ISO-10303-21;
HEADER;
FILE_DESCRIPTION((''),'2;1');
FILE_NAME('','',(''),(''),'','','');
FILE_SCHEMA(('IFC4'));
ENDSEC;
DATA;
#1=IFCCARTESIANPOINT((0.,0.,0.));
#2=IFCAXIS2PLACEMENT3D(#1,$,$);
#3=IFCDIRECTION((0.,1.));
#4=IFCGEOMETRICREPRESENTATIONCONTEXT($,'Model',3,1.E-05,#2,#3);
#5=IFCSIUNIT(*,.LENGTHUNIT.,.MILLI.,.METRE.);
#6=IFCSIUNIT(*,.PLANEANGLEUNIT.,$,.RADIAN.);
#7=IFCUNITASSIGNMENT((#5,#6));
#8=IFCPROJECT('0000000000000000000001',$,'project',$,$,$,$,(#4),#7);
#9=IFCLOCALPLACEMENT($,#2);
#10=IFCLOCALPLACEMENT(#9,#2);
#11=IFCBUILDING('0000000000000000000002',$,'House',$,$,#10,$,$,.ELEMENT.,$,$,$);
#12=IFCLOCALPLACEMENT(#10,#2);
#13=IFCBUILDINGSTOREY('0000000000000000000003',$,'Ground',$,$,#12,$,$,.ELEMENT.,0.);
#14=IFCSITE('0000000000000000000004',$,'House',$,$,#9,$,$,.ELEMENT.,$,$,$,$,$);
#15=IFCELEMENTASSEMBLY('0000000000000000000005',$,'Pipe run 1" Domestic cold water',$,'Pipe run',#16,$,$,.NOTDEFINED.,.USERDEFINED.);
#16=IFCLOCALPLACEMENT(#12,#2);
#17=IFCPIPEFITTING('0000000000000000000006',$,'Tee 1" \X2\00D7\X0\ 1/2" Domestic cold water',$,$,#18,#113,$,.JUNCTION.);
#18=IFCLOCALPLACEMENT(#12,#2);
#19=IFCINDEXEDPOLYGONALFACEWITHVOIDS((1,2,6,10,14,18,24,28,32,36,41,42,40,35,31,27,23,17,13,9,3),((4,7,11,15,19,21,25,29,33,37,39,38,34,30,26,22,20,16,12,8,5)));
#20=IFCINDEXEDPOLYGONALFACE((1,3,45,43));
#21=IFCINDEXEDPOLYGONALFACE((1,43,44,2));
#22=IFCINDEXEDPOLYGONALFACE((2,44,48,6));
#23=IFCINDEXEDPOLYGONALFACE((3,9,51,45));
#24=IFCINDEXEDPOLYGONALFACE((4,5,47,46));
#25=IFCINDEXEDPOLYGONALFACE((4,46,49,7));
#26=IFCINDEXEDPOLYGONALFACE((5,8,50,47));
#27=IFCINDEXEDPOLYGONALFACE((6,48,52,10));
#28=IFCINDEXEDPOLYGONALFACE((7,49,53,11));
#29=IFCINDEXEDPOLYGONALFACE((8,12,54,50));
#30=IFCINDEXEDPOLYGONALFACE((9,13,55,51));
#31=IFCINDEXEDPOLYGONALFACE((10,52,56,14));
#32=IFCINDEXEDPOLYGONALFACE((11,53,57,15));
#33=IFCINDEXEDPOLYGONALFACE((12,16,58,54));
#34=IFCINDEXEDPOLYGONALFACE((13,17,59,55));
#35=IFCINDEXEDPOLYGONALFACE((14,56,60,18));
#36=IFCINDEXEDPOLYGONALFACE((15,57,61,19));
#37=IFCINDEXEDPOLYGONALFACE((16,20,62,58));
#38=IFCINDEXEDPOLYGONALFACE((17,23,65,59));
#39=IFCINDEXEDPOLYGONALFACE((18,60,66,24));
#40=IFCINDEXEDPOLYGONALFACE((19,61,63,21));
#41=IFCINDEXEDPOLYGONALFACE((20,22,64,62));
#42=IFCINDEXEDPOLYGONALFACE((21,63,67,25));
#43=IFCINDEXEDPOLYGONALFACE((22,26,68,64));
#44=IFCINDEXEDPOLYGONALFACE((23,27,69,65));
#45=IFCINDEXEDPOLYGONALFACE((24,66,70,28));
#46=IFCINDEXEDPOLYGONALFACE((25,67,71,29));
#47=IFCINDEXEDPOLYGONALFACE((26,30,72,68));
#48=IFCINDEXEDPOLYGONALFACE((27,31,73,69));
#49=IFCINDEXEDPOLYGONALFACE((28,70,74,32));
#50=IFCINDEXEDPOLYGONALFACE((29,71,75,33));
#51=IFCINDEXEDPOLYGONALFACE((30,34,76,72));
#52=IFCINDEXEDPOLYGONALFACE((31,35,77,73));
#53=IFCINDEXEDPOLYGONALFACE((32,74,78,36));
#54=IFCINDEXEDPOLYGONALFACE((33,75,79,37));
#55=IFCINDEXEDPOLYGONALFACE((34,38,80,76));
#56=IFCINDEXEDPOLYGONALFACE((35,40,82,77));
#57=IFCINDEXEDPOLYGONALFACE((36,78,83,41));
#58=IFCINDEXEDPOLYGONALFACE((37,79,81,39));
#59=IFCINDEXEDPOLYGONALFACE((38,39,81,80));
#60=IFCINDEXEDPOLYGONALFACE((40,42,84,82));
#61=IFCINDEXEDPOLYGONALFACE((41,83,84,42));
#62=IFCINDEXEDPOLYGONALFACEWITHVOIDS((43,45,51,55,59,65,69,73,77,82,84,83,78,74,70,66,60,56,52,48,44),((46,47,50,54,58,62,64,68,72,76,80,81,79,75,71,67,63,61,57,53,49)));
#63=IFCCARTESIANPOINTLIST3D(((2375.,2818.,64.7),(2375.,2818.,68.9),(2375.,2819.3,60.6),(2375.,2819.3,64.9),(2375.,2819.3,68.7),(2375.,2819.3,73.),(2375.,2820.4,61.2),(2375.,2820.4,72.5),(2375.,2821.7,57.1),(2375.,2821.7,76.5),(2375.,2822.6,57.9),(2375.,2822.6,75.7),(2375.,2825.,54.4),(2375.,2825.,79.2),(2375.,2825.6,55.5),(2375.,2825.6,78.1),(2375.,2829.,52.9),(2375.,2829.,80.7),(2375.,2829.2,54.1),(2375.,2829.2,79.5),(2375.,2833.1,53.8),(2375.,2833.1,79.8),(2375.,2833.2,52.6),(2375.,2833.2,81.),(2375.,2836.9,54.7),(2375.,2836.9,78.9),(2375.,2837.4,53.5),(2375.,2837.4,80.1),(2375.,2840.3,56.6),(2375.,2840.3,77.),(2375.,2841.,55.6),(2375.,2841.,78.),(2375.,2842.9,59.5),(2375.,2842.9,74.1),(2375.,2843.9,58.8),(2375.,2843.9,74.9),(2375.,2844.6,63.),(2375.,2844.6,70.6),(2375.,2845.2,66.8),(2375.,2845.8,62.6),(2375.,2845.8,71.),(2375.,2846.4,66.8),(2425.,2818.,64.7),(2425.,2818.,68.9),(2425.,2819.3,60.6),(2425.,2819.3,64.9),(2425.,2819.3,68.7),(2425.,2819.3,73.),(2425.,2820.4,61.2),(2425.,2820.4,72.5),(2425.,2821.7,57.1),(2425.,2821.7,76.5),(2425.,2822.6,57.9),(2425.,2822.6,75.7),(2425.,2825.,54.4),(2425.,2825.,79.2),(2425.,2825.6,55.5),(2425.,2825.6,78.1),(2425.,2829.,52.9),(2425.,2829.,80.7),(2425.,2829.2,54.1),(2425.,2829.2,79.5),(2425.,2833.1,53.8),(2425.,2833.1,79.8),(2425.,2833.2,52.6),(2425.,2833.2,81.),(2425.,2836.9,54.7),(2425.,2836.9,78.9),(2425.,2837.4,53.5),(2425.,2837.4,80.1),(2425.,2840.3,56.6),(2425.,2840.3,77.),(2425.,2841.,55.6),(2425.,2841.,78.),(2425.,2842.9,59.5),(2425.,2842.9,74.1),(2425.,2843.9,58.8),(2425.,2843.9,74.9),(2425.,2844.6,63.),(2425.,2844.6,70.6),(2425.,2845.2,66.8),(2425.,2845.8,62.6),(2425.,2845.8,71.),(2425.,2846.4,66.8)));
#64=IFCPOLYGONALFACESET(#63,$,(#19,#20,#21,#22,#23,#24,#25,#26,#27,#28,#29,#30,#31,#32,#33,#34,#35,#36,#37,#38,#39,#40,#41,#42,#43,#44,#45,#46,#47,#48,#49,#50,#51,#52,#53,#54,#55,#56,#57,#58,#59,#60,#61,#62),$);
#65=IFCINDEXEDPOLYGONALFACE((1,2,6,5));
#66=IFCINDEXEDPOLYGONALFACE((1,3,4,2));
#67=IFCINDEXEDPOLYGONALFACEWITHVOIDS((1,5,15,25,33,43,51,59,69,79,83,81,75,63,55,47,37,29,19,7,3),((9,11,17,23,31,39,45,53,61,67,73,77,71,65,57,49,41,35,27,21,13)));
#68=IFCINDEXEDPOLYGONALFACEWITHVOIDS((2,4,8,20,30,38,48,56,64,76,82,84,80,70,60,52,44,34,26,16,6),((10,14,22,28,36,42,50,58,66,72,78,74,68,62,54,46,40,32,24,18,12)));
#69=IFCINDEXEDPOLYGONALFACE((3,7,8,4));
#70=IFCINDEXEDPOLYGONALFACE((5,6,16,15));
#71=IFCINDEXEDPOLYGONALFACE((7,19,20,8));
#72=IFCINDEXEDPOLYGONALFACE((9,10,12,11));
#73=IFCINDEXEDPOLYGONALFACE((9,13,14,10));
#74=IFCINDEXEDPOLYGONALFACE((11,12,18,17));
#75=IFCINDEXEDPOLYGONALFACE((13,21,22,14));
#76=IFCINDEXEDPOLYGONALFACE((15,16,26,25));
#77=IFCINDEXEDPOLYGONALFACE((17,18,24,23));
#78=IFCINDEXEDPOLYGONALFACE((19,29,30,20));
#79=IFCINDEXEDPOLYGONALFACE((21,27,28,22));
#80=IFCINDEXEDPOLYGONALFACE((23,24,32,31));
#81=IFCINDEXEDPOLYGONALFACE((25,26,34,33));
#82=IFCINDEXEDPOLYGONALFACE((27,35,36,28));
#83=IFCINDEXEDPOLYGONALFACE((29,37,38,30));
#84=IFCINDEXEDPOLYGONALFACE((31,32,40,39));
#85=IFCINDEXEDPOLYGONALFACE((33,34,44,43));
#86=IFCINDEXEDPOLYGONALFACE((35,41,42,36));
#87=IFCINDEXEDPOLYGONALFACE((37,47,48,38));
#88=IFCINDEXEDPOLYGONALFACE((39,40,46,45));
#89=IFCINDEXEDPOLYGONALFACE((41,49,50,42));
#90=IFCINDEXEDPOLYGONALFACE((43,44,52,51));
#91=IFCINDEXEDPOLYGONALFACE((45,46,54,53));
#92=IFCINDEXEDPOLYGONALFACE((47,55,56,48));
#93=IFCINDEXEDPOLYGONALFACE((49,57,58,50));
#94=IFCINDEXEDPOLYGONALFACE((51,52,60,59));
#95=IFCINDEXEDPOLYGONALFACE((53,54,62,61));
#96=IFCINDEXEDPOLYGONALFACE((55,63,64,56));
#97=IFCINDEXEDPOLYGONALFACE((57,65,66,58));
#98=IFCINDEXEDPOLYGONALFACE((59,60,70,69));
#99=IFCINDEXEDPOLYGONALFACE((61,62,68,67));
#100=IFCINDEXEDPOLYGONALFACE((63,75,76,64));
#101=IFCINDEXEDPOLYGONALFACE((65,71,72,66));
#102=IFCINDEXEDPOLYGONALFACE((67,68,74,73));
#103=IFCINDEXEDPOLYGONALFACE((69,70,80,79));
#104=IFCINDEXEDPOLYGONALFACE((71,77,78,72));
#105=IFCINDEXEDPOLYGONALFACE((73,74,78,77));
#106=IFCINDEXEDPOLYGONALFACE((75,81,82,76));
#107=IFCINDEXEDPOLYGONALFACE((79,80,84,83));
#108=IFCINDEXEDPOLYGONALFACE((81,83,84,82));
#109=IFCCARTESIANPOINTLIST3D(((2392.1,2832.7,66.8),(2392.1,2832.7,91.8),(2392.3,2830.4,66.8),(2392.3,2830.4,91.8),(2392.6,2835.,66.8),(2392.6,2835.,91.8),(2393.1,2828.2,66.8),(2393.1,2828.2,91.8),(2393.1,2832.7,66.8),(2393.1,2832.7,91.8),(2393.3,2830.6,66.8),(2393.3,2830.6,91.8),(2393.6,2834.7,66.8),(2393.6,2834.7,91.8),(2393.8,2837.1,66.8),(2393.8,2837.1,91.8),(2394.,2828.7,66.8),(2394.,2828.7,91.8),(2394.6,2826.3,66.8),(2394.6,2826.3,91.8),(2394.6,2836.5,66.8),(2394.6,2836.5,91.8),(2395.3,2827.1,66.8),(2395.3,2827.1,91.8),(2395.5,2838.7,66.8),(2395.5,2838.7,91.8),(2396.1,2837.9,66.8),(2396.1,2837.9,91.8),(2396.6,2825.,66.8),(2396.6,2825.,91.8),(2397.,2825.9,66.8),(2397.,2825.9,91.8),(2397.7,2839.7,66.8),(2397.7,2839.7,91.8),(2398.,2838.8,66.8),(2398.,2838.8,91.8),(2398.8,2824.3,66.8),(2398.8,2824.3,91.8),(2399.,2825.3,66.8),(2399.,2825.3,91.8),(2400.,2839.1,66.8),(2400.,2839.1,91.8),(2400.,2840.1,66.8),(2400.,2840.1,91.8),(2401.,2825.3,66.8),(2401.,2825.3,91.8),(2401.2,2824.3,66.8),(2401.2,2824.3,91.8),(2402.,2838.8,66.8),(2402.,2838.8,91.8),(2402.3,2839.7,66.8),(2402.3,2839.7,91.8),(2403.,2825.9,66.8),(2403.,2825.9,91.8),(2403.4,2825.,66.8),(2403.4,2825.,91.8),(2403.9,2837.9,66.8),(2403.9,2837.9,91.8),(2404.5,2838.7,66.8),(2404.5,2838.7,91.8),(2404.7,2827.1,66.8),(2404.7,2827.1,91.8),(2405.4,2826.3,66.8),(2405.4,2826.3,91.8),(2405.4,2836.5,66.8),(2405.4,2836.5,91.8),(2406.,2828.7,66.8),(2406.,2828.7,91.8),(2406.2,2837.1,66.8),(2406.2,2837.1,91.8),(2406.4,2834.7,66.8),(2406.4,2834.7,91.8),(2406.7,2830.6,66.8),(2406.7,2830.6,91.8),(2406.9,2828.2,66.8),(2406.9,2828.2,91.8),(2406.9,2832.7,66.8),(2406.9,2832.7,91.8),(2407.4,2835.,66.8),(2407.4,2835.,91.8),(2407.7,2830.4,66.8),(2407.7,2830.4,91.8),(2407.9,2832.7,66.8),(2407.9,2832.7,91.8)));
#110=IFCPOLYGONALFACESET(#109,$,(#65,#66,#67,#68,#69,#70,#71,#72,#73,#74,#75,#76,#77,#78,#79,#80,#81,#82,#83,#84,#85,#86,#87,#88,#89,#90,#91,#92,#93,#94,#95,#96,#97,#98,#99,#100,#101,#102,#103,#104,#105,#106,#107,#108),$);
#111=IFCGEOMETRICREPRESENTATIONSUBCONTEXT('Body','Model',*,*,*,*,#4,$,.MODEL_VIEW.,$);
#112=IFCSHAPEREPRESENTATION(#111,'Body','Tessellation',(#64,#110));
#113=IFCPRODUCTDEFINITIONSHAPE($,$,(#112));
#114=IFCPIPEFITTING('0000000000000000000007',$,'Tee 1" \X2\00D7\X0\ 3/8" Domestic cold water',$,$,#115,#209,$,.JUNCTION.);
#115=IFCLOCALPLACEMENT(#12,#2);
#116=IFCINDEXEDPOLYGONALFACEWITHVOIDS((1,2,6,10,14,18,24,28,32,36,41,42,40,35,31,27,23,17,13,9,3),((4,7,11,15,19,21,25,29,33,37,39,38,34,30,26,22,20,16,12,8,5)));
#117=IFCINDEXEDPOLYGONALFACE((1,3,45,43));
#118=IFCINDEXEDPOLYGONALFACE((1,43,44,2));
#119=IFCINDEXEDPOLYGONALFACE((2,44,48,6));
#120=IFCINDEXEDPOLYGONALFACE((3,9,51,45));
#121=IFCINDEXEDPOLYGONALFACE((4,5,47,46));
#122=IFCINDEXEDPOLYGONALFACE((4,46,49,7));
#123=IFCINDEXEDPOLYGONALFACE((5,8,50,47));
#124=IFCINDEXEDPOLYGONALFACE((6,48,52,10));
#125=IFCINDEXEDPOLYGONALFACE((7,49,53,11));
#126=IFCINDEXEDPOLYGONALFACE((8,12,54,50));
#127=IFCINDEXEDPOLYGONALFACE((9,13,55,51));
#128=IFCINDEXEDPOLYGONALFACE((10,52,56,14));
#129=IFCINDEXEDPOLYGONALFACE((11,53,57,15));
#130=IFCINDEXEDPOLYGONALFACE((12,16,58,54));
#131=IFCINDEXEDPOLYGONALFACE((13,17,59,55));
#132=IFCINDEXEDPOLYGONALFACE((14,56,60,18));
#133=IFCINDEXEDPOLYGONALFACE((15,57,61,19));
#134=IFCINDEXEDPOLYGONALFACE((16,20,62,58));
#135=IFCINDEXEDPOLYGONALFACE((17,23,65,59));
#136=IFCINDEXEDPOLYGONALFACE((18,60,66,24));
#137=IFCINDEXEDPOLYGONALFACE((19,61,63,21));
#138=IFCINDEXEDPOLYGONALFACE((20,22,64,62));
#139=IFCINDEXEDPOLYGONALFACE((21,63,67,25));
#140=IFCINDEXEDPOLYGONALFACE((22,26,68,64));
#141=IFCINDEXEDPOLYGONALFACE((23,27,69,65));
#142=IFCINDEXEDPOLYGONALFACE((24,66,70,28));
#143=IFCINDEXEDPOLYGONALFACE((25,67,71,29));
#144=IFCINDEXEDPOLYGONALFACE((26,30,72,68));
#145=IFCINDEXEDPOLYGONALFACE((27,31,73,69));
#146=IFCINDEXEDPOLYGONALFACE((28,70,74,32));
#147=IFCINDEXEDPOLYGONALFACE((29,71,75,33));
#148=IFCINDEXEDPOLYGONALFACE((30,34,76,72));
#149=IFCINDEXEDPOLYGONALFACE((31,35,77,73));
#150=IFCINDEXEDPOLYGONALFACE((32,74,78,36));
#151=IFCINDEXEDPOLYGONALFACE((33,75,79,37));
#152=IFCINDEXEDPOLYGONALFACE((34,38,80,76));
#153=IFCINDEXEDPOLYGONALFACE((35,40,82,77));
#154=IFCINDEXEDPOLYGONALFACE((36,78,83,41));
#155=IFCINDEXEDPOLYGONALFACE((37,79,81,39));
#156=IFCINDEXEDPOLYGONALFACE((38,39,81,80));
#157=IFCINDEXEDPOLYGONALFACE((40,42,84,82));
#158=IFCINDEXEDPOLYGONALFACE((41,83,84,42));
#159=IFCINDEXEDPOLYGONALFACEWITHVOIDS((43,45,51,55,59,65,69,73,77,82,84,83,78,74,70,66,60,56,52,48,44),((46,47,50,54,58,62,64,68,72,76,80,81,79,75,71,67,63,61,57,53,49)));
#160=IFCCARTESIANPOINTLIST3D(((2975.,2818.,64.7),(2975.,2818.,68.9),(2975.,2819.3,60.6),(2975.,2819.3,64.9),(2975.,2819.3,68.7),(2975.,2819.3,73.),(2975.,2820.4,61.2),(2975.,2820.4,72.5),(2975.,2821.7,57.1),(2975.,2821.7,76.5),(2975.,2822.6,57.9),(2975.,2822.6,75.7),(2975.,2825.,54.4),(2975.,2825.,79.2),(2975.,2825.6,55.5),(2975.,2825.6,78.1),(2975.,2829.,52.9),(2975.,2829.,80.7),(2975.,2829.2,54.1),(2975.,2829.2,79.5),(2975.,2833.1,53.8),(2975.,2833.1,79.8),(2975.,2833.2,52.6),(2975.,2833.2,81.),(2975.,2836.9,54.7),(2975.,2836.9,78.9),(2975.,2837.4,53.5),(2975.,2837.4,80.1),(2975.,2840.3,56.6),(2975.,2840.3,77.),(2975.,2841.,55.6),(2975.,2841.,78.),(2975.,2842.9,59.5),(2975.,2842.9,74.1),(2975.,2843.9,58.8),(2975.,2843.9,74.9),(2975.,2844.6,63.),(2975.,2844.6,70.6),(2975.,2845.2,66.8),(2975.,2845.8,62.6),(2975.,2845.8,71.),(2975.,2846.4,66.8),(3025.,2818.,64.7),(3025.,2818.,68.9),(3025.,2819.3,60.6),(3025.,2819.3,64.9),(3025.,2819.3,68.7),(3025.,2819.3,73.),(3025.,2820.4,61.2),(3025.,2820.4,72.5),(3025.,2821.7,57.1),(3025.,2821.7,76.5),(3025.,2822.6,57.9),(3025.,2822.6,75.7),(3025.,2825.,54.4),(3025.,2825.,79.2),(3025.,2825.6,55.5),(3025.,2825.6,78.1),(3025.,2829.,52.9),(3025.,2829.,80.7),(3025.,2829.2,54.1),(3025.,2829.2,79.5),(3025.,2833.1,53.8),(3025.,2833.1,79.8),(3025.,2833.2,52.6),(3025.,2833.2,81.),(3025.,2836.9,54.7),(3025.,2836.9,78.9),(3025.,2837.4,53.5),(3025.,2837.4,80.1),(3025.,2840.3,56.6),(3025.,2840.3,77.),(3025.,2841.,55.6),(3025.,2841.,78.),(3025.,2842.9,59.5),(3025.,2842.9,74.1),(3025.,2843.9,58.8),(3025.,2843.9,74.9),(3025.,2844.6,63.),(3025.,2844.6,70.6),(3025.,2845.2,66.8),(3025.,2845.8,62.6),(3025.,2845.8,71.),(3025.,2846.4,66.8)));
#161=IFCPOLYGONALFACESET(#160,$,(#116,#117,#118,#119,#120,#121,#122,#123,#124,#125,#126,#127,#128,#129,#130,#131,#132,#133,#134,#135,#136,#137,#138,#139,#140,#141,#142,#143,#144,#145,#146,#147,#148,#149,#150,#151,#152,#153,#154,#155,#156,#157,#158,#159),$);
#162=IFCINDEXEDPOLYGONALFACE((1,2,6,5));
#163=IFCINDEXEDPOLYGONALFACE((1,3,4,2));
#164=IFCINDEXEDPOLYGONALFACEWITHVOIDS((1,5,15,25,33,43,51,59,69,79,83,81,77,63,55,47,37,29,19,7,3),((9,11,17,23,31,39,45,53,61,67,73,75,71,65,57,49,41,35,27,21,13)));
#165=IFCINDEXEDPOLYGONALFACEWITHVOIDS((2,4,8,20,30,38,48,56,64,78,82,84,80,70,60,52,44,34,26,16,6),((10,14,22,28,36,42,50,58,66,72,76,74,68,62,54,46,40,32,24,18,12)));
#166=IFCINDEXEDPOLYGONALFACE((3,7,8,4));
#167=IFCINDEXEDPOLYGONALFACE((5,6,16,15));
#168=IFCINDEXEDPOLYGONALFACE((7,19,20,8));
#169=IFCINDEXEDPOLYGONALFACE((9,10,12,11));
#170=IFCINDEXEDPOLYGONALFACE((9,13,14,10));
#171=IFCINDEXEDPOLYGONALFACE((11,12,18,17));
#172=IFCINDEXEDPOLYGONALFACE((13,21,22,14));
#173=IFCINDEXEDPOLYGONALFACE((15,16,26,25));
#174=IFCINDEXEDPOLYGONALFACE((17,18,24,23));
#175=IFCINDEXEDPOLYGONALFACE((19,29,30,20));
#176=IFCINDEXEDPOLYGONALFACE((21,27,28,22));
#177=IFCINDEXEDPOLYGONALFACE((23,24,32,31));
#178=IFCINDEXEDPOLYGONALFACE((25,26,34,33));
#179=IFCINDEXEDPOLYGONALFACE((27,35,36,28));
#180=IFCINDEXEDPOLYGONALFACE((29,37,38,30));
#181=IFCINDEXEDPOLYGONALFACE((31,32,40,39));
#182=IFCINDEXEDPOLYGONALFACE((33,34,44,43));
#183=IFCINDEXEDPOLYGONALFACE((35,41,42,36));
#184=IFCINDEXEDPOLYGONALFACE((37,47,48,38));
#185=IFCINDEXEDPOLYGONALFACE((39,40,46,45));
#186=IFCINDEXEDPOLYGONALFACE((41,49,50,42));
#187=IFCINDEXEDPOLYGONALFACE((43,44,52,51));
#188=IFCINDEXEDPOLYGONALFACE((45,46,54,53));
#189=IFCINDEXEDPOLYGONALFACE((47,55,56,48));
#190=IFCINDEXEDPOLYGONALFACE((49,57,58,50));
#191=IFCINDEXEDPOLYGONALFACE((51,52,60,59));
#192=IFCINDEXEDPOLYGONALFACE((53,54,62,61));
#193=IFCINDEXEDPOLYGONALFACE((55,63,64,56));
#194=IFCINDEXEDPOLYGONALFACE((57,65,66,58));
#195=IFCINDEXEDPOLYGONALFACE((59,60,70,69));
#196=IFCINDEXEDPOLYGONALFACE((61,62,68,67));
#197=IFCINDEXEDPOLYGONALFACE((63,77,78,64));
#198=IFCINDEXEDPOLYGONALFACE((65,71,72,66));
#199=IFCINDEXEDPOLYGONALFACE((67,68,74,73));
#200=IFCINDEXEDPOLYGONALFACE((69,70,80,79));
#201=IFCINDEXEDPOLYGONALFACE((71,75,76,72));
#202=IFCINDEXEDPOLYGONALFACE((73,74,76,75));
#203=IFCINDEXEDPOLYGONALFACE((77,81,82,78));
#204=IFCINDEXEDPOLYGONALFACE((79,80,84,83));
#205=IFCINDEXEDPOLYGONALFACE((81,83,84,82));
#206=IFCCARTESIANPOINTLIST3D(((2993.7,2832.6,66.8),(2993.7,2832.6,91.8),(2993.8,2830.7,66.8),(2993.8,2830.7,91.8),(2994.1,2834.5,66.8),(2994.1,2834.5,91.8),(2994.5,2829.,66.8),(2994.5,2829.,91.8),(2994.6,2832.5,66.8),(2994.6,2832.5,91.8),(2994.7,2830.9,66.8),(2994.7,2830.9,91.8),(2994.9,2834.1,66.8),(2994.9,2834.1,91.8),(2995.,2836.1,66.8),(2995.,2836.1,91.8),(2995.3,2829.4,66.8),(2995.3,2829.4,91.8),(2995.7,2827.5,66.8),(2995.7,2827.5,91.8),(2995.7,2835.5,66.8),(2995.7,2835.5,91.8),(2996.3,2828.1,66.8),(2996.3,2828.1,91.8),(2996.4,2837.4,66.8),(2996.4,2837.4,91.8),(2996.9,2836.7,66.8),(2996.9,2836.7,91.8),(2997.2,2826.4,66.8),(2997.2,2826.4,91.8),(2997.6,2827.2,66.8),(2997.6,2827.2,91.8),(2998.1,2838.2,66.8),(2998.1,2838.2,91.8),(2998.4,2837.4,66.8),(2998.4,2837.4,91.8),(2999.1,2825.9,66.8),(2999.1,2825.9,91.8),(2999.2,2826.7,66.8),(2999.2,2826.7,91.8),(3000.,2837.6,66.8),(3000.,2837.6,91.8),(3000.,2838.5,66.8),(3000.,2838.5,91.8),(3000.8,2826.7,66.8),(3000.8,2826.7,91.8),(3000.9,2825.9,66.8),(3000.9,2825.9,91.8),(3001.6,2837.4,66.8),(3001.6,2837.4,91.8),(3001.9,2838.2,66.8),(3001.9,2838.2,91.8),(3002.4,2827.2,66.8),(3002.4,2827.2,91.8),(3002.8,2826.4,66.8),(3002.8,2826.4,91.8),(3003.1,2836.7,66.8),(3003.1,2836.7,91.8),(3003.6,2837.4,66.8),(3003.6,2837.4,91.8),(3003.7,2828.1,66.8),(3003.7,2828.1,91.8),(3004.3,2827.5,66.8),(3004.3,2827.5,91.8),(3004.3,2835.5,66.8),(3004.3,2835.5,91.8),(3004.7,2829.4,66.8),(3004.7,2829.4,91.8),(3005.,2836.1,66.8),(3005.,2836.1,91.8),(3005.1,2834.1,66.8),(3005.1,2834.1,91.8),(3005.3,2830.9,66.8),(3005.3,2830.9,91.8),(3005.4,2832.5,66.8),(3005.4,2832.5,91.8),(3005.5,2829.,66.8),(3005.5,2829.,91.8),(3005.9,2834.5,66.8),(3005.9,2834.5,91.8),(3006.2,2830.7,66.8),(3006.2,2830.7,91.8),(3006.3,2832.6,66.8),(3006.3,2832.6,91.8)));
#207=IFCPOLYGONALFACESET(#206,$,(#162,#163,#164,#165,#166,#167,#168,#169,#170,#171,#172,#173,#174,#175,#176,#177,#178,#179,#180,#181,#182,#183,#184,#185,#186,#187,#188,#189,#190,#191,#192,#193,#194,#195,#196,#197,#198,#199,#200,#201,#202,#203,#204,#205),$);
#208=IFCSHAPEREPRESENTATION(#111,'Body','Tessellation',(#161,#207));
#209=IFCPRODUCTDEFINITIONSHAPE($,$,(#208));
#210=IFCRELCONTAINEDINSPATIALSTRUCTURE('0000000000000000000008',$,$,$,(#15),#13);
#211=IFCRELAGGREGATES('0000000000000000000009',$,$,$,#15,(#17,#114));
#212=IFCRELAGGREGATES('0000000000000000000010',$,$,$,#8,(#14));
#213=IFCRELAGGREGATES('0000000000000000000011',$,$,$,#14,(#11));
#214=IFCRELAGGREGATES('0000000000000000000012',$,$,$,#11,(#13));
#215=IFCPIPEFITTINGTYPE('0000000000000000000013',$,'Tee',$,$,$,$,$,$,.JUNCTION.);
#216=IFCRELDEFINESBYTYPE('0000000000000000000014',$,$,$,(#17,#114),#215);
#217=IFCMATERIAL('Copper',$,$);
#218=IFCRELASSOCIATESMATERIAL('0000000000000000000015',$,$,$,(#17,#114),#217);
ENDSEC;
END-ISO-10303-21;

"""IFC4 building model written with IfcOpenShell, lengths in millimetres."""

from ifc_helpers import new_model, si_unit, direction, frame, origin, origin_with_axes, origin_2d, place, context, subcontext, project, spatial, hollow_circle, extrude, material, type_object, element, aggregate, save


model = new_model("IFC4")

# Units and contexts
model_context = context("Model", 3, precision=1e-05, world=origin(), true_north=direction((0.0, 1.0)))
body_context = subcontext(model_context, "Body", "Model", "MODEL_VIEW")
ifc_project = project(units=[si_unit("LENGTHUNIT", "METRE", prefix="MILLI"), si_unit("PLANEANGLEUNIT", "RADIAN")], contexts=[model_context])

# Site, building, storey
site_placement = place(None, origin())
site = spatial("IfcSite", under=ifc_project, at=site_placement, Name="House", CompositionType="ELEMENT")
building_placement = place(site_placement, origin())
building = spatial("IfcBuilding", under=site, at=building_placement, Name="House", CompositionType="ELEMENT")
storey_placement = place(building_placement, origin())
storey = spatial("IfcBuildingStorey", under=building, at=storey_placement, Name="Ground", CompositionType="ELEMENT", Elevation=0.0)

# Shared definitions
ifc_material = material(Name="Copper")

# Element assembly
assembly_1_placement = place(storey_placement, origin_with_axes())
assembly_1 = element("IfcElementAssembly", 1, at=assembly_1_placement, inside=storey, Name="Pipe run 1\" Domestic cold water", ObjectType="Pipe run", AssemblyPlace="NOTDEFINED", PredefinedType="USERDEFINED")

# Pipe fittings
pipe_fitting_type_1 = type_object("IfcPipeFittingType", Name="Tee", PredefinedType="JUNCTION")
pipe_fitting_1_placement = place(storey_placement, origin_with_axes())
pipe_fitting_1 = element("IfcPipeFitting", 2, at=pipe_fitting_1_placement, type_object=pipe_fitting_type_1, material=ifc_material, Name="Tee 1\" × 1/2\" Domestic cold water", PredefinedType="JUNCTION", context=body_context, shape_type="SweptSolid", body=[
    extrude(hollow_circle(Radius=14.3, WallThickness=1.3, at=origin_2d()), frame((2375.0, 2832.1, 66.8), z_axis=(1.0, 0.0, 0.0), x_axis=(0.0, 1.0, 0.0)), (0.0, 0.0, 1.0), 50.0),
    extrude(hollow_circle(Radius=7.9, WallThickness=1.0, at=origin_2d()), frame((2400.0, 2832.1, 66.8), z_axis=(0.0, 0.0, 1.0), x_axis=(0.0, 1.0, 0.0)), (0.0, 0.0, 1.0), 25.0),
])
pipe_fitting_2_placement = place(storey_placement, origin_with_axes())
pipe_fitting_2 = element("IfcPipeFitting", 3, at=pipe_fitting_2_placement, type_object=pipe_fitting_type_1, material=ifc_material, Name="Tee 1\" × 3/8\" Domestic cold water", PredefinedType="JUNCTION", context=body_context, shape_type="SweptSolid", body=[
    extrude(hollow_circle(Radius=14.3, WallThickness=1.3, at=origin_2d()), frame((2975.0, 2832.1, 66.8), z_axis=(1.0, 0.0, 0.0), x_axis=(0.0, 1.0, 0.0)), (0.0, 0.0, 1.0), 50.0),
    extrude(hollow_circle(Radius=6.3, WallThickness=0.9, at=origin_2d()), frame((3000.0, 2832.1, 66.8), z_axis=(0.0, 0.0, 1.0), x_axis=(0.0, 1.0, 0.0)), (0.0, 0.0, 1.0), 25.0),
])
aggregate(assembly_1, [pipe_fitting_1, pipe_fitting_2])

save(model, "model.ifc")
